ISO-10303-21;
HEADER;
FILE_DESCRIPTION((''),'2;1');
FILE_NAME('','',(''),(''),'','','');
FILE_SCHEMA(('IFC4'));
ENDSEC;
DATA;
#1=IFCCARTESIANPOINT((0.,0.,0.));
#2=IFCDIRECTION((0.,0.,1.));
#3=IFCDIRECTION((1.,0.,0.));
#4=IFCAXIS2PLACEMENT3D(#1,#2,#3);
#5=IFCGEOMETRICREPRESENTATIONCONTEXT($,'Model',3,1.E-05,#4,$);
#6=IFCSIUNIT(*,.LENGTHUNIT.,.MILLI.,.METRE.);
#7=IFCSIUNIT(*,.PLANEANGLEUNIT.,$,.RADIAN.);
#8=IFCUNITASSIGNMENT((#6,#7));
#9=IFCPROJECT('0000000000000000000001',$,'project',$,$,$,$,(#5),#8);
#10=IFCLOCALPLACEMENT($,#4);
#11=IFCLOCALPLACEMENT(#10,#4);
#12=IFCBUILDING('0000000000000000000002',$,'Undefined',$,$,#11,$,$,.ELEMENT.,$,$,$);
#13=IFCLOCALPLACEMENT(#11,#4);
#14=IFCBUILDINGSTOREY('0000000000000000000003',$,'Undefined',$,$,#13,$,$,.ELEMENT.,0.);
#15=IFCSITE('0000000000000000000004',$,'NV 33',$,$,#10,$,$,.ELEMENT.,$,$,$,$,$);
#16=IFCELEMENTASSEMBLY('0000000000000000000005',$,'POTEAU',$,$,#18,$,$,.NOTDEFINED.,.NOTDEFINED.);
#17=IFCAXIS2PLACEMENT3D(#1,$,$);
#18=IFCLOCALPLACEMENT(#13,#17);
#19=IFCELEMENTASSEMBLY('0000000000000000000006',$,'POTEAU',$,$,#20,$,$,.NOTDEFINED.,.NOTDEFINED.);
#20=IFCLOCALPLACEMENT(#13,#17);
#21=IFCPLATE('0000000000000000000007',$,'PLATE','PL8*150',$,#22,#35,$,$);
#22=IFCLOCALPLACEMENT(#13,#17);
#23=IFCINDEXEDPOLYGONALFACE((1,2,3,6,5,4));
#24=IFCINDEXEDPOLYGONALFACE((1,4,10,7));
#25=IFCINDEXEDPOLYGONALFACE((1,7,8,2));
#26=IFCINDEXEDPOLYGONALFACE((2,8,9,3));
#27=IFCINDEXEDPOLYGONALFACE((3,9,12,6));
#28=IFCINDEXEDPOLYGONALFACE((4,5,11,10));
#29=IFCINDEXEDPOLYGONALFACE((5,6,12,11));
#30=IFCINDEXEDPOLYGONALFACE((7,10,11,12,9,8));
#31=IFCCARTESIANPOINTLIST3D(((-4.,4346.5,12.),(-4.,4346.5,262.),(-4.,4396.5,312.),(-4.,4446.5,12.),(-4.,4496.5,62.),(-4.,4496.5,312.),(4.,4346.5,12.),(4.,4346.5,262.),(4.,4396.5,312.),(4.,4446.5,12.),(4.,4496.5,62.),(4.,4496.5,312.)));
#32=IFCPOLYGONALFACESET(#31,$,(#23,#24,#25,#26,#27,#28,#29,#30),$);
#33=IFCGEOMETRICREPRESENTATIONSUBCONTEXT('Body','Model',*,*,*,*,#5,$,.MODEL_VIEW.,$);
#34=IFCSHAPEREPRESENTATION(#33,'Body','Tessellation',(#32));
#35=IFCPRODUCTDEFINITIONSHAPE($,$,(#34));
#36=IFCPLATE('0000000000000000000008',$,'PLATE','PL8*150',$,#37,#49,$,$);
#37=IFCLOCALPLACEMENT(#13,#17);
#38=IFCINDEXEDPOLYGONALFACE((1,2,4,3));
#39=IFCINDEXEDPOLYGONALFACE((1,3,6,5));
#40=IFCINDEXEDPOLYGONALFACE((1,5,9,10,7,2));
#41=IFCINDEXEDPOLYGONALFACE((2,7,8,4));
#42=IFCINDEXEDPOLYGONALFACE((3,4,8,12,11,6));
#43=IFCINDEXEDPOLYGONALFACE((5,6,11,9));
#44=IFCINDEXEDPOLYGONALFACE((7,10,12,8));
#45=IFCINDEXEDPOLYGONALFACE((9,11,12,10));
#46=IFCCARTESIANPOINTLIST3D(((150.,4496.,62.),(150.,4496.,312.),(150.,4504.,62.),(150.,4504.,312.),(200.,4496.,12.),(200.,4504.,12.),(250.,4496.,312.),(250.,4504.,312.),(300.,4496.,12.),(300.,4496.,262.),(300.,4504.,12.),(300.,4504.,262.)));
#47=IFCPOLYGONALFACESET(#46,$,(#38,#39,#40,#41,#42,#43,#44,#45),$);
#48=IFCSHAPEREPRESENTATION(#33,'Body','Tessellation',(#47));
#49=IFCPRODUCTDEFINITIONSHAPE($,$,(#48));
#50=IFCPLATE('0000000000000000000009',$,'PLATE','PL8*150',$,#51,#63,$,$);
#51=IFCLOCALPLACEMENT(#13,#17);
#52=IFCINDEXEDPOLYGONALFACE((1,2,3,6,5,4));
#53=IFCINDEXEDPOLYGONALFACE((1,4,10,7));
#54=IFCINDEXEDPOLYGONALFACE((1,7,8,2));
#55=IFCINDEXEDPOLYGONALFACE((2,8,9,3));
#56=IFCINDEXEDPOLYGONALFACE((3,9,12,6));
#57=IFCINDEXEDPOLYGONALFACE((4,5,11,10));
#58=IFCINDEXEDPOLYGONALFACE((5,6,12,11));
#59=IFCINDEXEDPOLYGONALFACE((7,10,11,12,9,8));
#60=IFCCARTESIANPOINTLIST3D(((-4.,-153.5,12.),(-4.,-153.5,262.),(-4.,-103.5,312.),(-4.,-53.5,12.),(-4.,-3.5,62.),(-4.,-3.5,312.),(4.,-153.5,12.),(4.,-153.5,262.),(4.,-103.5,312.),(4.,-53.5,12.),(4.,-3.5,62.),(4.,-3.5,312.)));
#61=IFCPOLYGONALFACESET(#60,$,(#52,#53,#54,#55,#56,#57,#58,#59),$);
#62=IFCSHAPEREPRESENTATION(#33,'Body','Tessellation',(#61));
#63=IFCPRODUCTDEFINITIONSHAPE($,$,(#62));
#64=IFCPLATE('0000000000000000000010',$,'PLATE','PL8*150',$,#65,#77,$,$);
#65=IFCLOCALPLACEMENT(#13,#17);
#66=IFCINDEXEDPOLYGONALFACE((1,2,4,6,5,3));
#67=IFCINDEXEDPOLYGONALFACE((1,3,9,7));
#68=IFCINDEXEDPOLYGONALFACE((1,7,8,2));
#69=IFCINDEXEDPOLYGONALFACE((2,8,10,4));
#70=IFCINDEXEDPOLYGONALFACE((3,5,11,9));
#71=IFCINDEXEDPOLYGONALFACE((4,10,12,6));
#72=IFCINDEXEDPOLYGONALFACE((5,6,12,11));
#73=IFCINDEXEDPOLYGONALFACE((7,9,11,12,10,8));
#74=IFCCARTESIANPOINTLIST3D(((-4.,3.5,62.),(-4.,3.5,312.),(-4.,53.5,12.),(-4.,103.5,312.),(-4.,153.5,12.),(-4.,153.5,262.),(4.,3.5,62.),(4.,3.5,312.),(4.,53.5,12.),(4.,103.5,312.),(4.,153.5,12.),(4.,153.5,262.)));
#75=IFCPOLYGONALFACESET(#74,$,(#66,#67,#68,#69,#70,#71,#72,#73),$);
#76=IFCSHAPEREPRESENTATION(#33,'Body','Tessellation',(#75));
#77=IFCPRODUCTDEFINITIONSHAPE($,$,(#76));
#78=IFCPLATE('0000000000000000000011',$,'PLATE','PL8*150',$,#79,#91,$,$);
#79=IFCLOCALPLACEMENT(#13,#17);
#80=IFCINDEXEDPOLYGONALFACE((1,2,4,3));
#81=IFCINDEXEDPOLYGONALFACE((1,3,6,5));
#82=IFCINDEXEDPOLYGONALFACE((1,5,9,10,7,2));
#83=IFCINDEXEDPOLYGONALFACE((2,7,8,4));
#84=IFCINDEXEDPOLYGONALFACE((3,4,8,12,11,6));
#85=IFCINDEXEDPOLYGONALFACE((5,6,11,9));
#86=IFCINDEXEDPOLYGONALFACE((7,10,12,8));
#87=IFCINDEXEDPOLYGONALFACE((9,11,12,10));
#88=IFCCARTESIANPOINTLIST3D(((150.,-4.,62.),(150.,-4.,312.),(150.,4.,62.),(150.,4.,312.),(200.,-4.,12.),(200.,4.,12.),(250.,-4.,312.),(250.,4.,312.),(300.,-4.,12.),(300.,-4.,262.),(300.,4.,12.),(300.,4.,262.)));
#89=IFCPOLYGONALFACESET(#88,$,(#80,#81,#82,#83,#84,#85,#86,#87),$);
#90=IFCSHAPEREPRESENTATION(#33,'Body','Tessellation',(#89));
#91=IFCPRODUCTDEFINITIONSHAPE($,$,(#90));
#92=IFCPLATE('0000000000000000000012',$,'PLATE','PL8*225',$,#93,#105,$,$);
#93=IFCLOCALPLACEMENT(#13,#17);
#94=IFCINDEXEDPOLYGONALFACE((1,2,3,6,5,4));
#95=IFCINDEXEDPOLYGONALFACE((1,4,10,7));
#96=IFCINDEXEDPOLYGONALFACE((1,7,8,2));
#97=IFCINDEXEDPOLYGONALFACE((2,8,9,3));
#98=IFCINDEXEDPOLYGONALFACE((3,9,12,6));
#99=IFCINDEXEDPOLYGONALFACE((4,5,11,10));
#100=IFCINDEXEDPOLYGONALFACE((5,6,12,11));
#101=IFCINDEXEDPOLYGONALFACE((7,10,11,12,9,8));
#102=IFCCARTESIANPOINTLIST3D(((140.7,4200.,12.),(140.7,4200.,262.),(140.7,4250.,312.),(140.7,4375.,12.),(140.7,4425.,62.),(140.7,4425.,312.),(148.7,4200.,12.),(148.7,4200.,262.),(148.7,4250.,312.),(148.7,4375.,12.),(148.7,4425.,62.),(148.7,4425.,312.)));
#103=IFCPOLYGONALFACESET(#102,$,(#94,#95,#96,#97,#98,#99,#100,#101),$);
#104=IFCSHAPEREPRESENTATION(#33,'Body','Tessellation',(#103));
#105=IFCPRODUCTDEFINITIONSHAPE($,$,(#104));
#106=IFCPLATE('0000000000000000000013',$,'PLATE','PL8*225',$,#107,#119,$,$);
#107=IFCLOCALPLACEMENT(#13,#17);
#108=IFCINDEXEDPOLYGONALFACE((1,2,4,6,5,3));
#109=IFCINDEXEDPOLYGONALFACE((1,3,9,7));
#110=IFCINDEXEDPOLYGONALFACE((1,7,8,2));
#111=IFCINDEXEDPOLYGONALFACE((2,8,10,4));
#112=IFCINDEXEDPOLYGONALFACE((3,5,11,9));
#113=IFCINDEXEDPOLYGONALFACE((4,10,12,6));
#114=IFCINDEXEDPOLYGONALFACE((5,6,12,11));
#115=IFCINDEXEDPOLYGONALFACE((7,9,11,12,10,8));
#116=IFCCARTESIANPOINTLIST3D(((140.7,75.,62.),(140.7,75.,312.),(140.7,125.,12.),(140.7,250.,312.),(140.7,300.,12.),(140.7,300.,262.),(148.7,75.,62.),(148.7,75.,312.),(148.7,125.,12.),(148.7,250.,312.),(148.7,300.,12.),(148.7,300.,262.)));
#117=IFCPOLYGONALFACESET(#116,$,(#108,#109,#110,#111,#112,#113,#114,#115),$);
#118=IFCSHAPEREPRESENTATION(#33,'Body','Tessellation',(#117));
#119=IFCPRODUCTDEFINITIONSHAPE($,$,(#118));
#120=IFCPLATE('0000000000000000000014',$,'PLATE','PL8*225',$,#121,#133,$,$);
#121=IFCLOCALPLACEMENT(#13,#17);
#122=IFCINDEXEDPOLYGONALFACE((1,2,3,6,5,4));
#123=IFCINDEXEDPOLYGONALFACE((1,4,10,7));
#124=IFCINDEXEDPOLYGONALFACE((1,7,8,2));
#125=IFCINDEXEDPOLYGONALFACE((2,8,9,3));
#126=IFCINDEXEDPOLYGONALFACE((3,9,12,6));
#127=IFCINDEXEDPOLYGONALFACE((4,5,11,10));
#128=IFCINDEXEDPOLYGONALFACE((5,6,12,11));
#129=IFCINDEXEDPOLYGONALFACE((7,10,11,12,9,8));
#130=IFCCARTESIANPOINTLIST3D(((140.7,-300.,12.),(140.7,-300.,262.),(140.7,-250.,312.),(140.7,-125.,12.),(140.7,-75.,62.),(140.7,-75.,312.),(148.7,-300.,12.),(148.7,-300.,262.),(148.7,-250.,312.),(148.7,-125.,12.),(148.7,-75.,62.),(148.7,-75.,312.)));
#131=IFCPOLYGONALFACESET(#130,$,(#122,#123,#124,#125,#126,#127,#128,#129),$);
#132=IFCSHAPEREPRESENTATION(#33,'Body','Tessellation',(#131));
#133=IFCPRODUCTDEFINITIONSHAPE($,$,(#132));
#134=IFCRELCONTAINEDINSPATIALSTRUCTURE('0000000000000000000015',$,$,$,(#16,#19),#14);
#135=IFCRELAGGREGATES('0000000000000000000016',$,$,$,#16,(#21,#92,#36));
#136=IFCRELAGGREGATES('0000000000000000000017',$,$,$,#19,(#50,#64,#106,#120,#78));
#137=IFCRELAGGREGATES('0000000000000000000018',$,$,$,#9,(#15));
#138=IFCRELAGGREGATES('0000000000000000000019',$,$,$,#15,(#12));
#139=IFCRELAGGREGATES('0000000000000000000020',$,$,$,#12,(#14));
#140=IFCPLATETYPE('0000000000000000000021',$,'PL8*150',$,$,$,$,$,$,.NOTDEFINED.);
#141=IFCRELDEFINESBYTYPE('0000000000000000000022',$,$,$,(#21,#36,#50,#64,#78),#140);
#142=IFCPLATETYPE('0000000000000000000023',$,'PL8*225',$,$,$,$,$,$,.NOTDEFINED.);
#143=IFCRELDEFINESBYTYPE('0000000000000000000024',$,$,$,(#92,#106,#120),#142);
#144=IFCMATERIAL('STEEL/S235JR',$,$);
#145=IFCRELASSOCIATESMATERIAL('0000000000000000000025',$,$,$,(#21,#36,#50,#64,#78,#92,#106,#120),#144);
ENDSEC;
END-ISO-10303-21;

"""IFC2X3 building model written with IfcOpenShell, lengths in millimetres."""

from ifc_helpers import new_model, si_unit, frame, origin_with_axes, place, context, subcontext, project, spatial, polyline, outline, extrude, material, type_object, element, aggregate, save


model = new_model("IFC2X3")

# Units and contexts
model_context = context("Model", 3, precision=1e-05, world=origin_with_axes())
body_context = subcontext(model_context, "Body", "Model", "MODEL_VIEW")
ifc_project = project(units=[si_unit("LENGTHUNIT", "METRE", prefix="MILLI"), si_unit("PLANEANGLEUNIT", "RADIAN")], contexts=[model_context])

# Site, building, storey
site_placement = place(None, origin_with_axes())
site = spatial("IfcSite", under=ifc_project, at=site_placement, Name="NV 33", CompositionType="ELEMENT")
building_placement = place(site_placement, origin_with_axes())
building = spatial("IfcBuilding", under=site, at=building_placement, Name="Undefined", CompositionType="ELEMENT")
storey_placement = place(building_placement, origin_with_axes())
storey = spatial("IfcBuildingStorey", under=building, at=storey_placement, Name="Undefined", CompositionType="ELEMENT", Elevation=0.0)

# Element assemblies
assembly_1_placement = place(storey_placement, origin_with_axes())
assembly_1 = element("IfcElementAssembly", 1, at=assembly_1_placement, inside=storey, Name="POTEAU", AssemblyPlace="NOTDEFINED", PredefinedType="NOTDEFINED")
ifc_material = material(Name="STEEL/S235JR")
assembly_2_placement = place(storey_placement, origin_with_axes())
assembly_2 = element("IfcElementAssembly", 2, at=assembly_2_placement, inside=storey, Name="POTEAU", AssemblyPlace="NOTDEFINED", PredefinedType="NOTDEFINED")

# Plates
plate_type_1 = type_object("IfcPlateType", Name="PL8*150", PredefinedType="NOTDEFINED")
plate_1_placement = place(assembly_1_placement, frame((0.0, 4496.5, 12.0), z_axis=(-1.0, 0.0, 0.0), x_axis=(0.0, -1.0, 0.0)))
plate_1 = element("IfcPlate", 3, at=plate_1_placement, type_object=plate_type_1, material=ifc_material, Name="PLATE", Description="PL8*150", context=body_context, shape_type="SweptSolid", body=[
    extrude(outline(polyline([(0.0, 50.0), (50.0, 0.0), (150.0, 0.0), (150.0, 250.0), (100.0, 300.0), (0.0, 300.0), (0.0, 50.0)])), frame((0.0, 0.0, -4.0), z_axis=(0.0, 0.0, 1.0), x_axis=(1.0, 0.0, 0.0)), (0.0, 0.0, 1.0), 8.0),
])
plate_2_placement = place(assembly_1_placement, frame((150.0, 4500.0, 12.0), z_axis=(0.0, -1.0, 0.0), x_axis=(1.0, 0.0, 0.0)))
plate_2 = element("IfcPlate", 4, at=plate_2_placement, type_object=plate_type_1, material=ifc_material, Name="PLATE", Description="PL8*150", context=body_context, shape_type="SweptSolid", body=[
    extrude(outline(polyline([(0.0, 50.0), (50.0, 0.0), (150.0, 0.0), (150.0, 250.0), (100.0, 300.0), (0.0, 300.0), (0.0, 50.0)])), frame((0.0, 0.0, -4.0), z_axis=(0.0, 0.0, 1.0), x_axis=(1.0, 0.0, 0.0)), (0.0, 0.0, 1.0), 8.0),
])
plate_3_placement = place(assembly_2_placement, frame((0.0, -3.5, 12.0), z_axis=(-1.0, 0.0, 0.0), x_axis=(0.0, -1.0, 0.0)))
plate_3 = element("IfcPlate", 5, at=plate_3_placement, type_object=plate_type_1, material=ifc_material, Name="PLATE", Description="PL8*150", context=body_context, shape_type="SweptSolid", body=[
    extrude(outline(polyline([(0.0, 50.0), (50.0, 0.0), (150.0, 0.0), (150.0, 250.0), (100.0, 300.0), (0.0, 300.0), (0.0, 50.0)])), frame((0.0, 0.0, -4.0), z_axis=(0.0, 0.0, 1.0), x_axis=(1.0, 0.0, 0.0)), (0.0, 0.0, 1.0), 8.0),
])
plate_4_placement = place(assembly_2_placement, frame((0.0, 3.5, 12.0), z_axis=(1.0, 0.0, 0.0), x_axis=(0.0, 1.0, 0.0)))
plate_4 = element("IfcPlate", 6, at=plate_4_placement, type_object=plate_type_1, material=ifc_material, Name="PLATE", Description="PL8*150", context=body_context, shape_type="SweptSolid", body=[
    extrude(outline(polyline([(0.0, 50.0), (50.0, 0.0), (150.0, 0.0), (150.0, 250.0), (100.0, 300.0), (0.0, 300.0), (0.0, 50.0)])), frame((0.0, 0.0, -4.0), z_axis=(0.0, 0.0, 1.0), x_axis=(1.0, 0.0, 0.0)), (0.0, 0.0, 1.0), 8.0),
])
plate_5_placement = place(assembly_2_placement, frame((150.0, 0.0, 12.0), z_axis=(0.0, -1.0, 0.0), x_axis=(1.0, 0.0, 0.0)))
plate_5 = element("IfcPlate", 7, at=plate_5_placement, type_object=plate_type_1, material=ifc_material, Name="PLATE", Description="PL8*150", context=body_context, shape_type="SweptSolid", body=[
    extrude(outline(polyline([(0.0, 50.0), (50.0, 0.0), (150.0, 0.0), (150.0, 250.0), (100.0, 300.0), (0.0, 300.0), (0.0, 50.0)])), frame((0.0, 0.0, -4.0), z_axis=(0.0, 0.0, 1.0), x_axis=(1.0, 0.0, 0.0)), (0.0, 0.0, 1.0), 8.0),
])
plate_type_2 = type_object("IfcPlateType", Name="PL8*225", PredefinedType="NOTDEFINED")
plate_6_placement = place(assembly_1_placement, frame((144.7, 4425.0, 12.0), z_axis=(-1.0, 0.0, 0.0), x_axis=(0.0, -1.0, 0.0)))
plate_6 = element("IfcPlate", 8, at=plate_6_placement, type_object=plate_type_2, material=ifc_material, Name="PLATE", Description="PL8*225", context=body_context, shape_type="SweptSolid", body=[
    extrude(outline(polyline([(0.0, 50.0), (50.0, 0.0), (225.0, 0.0), (225.0, 250.0), (175.0, 300.0), (0.0, 300.0), (0.0, 50.0)])), frame((0.0, 0.0, -4.0), z_axis=(0.0, 0.0, 1.0), x_axis=(1.0, 0.0, 0.0)), (0.0, 0.0, 1.0), 8.0),
])
aggregate(assembly_1, [plate_1, plate_6, plate_2])
plate_7_placement = place(assembly_2_placement, frame((144.7, 75.0, 12.0), z_axis=(1.0, 0.0, 0.0), x_axis=(0.0, 1.0, 0.0)))
plate_7 = element("IfcPlate", 9, at=plate_7_placement, type_object=plate_type_2, material=ifc_material, Name="PLATE", Description="PL8*225", context=body_context, shape_type="SweptSolid", body=[
    extrude(outline(polyline([(0.0, 50.0), (50.0, 0.0), (225.0, 0.0), (225.0, 250.0), (175.0, 300.0), (0.0, 300.0), (0.0, 50.0)])), frame((0.0, 0.0, -4.0), z_axis=(0.0, 0.0, 1.0), x_axis=(1.0, 0.0, 0.0)), (0.0, 0.0, 1.0), 8.0),
])
plate_8_placement = place(assembly_2_placement, frame((144.7, -75.0, 12.0), z_axis=(-1.0, 0.0, 0.0), x_axis=(0.0, -1.0, 0.0)))
plate_8 = element("IfcPlate", 10, at=plate_8_placement, type_object=plate_type_2, material=ifc_material, Name="PLATE", Description="PL8*225", context=body_context, shape_type="SweptSolid", body=[
    extrude(outline(polyline([(0.0, 50.0), (50.0, 0.0), (225.0, 0.0), (225.0, 250.0), (175.0, 300.0), (0.0, 300.0), (0.0, 50.0)])), frame((0.0, 0.0, -4.0), z_axis=(0.0, 0.0, 1.0), x_axis=(1.0, 0.0, 0.0)), (0.0, 0.0, 1.0), 8.0),
])
aggregate(assembly_2, [plate_3, plate_4, plate_7, plate_8, plate_5])

save(model, "model.ifc")
